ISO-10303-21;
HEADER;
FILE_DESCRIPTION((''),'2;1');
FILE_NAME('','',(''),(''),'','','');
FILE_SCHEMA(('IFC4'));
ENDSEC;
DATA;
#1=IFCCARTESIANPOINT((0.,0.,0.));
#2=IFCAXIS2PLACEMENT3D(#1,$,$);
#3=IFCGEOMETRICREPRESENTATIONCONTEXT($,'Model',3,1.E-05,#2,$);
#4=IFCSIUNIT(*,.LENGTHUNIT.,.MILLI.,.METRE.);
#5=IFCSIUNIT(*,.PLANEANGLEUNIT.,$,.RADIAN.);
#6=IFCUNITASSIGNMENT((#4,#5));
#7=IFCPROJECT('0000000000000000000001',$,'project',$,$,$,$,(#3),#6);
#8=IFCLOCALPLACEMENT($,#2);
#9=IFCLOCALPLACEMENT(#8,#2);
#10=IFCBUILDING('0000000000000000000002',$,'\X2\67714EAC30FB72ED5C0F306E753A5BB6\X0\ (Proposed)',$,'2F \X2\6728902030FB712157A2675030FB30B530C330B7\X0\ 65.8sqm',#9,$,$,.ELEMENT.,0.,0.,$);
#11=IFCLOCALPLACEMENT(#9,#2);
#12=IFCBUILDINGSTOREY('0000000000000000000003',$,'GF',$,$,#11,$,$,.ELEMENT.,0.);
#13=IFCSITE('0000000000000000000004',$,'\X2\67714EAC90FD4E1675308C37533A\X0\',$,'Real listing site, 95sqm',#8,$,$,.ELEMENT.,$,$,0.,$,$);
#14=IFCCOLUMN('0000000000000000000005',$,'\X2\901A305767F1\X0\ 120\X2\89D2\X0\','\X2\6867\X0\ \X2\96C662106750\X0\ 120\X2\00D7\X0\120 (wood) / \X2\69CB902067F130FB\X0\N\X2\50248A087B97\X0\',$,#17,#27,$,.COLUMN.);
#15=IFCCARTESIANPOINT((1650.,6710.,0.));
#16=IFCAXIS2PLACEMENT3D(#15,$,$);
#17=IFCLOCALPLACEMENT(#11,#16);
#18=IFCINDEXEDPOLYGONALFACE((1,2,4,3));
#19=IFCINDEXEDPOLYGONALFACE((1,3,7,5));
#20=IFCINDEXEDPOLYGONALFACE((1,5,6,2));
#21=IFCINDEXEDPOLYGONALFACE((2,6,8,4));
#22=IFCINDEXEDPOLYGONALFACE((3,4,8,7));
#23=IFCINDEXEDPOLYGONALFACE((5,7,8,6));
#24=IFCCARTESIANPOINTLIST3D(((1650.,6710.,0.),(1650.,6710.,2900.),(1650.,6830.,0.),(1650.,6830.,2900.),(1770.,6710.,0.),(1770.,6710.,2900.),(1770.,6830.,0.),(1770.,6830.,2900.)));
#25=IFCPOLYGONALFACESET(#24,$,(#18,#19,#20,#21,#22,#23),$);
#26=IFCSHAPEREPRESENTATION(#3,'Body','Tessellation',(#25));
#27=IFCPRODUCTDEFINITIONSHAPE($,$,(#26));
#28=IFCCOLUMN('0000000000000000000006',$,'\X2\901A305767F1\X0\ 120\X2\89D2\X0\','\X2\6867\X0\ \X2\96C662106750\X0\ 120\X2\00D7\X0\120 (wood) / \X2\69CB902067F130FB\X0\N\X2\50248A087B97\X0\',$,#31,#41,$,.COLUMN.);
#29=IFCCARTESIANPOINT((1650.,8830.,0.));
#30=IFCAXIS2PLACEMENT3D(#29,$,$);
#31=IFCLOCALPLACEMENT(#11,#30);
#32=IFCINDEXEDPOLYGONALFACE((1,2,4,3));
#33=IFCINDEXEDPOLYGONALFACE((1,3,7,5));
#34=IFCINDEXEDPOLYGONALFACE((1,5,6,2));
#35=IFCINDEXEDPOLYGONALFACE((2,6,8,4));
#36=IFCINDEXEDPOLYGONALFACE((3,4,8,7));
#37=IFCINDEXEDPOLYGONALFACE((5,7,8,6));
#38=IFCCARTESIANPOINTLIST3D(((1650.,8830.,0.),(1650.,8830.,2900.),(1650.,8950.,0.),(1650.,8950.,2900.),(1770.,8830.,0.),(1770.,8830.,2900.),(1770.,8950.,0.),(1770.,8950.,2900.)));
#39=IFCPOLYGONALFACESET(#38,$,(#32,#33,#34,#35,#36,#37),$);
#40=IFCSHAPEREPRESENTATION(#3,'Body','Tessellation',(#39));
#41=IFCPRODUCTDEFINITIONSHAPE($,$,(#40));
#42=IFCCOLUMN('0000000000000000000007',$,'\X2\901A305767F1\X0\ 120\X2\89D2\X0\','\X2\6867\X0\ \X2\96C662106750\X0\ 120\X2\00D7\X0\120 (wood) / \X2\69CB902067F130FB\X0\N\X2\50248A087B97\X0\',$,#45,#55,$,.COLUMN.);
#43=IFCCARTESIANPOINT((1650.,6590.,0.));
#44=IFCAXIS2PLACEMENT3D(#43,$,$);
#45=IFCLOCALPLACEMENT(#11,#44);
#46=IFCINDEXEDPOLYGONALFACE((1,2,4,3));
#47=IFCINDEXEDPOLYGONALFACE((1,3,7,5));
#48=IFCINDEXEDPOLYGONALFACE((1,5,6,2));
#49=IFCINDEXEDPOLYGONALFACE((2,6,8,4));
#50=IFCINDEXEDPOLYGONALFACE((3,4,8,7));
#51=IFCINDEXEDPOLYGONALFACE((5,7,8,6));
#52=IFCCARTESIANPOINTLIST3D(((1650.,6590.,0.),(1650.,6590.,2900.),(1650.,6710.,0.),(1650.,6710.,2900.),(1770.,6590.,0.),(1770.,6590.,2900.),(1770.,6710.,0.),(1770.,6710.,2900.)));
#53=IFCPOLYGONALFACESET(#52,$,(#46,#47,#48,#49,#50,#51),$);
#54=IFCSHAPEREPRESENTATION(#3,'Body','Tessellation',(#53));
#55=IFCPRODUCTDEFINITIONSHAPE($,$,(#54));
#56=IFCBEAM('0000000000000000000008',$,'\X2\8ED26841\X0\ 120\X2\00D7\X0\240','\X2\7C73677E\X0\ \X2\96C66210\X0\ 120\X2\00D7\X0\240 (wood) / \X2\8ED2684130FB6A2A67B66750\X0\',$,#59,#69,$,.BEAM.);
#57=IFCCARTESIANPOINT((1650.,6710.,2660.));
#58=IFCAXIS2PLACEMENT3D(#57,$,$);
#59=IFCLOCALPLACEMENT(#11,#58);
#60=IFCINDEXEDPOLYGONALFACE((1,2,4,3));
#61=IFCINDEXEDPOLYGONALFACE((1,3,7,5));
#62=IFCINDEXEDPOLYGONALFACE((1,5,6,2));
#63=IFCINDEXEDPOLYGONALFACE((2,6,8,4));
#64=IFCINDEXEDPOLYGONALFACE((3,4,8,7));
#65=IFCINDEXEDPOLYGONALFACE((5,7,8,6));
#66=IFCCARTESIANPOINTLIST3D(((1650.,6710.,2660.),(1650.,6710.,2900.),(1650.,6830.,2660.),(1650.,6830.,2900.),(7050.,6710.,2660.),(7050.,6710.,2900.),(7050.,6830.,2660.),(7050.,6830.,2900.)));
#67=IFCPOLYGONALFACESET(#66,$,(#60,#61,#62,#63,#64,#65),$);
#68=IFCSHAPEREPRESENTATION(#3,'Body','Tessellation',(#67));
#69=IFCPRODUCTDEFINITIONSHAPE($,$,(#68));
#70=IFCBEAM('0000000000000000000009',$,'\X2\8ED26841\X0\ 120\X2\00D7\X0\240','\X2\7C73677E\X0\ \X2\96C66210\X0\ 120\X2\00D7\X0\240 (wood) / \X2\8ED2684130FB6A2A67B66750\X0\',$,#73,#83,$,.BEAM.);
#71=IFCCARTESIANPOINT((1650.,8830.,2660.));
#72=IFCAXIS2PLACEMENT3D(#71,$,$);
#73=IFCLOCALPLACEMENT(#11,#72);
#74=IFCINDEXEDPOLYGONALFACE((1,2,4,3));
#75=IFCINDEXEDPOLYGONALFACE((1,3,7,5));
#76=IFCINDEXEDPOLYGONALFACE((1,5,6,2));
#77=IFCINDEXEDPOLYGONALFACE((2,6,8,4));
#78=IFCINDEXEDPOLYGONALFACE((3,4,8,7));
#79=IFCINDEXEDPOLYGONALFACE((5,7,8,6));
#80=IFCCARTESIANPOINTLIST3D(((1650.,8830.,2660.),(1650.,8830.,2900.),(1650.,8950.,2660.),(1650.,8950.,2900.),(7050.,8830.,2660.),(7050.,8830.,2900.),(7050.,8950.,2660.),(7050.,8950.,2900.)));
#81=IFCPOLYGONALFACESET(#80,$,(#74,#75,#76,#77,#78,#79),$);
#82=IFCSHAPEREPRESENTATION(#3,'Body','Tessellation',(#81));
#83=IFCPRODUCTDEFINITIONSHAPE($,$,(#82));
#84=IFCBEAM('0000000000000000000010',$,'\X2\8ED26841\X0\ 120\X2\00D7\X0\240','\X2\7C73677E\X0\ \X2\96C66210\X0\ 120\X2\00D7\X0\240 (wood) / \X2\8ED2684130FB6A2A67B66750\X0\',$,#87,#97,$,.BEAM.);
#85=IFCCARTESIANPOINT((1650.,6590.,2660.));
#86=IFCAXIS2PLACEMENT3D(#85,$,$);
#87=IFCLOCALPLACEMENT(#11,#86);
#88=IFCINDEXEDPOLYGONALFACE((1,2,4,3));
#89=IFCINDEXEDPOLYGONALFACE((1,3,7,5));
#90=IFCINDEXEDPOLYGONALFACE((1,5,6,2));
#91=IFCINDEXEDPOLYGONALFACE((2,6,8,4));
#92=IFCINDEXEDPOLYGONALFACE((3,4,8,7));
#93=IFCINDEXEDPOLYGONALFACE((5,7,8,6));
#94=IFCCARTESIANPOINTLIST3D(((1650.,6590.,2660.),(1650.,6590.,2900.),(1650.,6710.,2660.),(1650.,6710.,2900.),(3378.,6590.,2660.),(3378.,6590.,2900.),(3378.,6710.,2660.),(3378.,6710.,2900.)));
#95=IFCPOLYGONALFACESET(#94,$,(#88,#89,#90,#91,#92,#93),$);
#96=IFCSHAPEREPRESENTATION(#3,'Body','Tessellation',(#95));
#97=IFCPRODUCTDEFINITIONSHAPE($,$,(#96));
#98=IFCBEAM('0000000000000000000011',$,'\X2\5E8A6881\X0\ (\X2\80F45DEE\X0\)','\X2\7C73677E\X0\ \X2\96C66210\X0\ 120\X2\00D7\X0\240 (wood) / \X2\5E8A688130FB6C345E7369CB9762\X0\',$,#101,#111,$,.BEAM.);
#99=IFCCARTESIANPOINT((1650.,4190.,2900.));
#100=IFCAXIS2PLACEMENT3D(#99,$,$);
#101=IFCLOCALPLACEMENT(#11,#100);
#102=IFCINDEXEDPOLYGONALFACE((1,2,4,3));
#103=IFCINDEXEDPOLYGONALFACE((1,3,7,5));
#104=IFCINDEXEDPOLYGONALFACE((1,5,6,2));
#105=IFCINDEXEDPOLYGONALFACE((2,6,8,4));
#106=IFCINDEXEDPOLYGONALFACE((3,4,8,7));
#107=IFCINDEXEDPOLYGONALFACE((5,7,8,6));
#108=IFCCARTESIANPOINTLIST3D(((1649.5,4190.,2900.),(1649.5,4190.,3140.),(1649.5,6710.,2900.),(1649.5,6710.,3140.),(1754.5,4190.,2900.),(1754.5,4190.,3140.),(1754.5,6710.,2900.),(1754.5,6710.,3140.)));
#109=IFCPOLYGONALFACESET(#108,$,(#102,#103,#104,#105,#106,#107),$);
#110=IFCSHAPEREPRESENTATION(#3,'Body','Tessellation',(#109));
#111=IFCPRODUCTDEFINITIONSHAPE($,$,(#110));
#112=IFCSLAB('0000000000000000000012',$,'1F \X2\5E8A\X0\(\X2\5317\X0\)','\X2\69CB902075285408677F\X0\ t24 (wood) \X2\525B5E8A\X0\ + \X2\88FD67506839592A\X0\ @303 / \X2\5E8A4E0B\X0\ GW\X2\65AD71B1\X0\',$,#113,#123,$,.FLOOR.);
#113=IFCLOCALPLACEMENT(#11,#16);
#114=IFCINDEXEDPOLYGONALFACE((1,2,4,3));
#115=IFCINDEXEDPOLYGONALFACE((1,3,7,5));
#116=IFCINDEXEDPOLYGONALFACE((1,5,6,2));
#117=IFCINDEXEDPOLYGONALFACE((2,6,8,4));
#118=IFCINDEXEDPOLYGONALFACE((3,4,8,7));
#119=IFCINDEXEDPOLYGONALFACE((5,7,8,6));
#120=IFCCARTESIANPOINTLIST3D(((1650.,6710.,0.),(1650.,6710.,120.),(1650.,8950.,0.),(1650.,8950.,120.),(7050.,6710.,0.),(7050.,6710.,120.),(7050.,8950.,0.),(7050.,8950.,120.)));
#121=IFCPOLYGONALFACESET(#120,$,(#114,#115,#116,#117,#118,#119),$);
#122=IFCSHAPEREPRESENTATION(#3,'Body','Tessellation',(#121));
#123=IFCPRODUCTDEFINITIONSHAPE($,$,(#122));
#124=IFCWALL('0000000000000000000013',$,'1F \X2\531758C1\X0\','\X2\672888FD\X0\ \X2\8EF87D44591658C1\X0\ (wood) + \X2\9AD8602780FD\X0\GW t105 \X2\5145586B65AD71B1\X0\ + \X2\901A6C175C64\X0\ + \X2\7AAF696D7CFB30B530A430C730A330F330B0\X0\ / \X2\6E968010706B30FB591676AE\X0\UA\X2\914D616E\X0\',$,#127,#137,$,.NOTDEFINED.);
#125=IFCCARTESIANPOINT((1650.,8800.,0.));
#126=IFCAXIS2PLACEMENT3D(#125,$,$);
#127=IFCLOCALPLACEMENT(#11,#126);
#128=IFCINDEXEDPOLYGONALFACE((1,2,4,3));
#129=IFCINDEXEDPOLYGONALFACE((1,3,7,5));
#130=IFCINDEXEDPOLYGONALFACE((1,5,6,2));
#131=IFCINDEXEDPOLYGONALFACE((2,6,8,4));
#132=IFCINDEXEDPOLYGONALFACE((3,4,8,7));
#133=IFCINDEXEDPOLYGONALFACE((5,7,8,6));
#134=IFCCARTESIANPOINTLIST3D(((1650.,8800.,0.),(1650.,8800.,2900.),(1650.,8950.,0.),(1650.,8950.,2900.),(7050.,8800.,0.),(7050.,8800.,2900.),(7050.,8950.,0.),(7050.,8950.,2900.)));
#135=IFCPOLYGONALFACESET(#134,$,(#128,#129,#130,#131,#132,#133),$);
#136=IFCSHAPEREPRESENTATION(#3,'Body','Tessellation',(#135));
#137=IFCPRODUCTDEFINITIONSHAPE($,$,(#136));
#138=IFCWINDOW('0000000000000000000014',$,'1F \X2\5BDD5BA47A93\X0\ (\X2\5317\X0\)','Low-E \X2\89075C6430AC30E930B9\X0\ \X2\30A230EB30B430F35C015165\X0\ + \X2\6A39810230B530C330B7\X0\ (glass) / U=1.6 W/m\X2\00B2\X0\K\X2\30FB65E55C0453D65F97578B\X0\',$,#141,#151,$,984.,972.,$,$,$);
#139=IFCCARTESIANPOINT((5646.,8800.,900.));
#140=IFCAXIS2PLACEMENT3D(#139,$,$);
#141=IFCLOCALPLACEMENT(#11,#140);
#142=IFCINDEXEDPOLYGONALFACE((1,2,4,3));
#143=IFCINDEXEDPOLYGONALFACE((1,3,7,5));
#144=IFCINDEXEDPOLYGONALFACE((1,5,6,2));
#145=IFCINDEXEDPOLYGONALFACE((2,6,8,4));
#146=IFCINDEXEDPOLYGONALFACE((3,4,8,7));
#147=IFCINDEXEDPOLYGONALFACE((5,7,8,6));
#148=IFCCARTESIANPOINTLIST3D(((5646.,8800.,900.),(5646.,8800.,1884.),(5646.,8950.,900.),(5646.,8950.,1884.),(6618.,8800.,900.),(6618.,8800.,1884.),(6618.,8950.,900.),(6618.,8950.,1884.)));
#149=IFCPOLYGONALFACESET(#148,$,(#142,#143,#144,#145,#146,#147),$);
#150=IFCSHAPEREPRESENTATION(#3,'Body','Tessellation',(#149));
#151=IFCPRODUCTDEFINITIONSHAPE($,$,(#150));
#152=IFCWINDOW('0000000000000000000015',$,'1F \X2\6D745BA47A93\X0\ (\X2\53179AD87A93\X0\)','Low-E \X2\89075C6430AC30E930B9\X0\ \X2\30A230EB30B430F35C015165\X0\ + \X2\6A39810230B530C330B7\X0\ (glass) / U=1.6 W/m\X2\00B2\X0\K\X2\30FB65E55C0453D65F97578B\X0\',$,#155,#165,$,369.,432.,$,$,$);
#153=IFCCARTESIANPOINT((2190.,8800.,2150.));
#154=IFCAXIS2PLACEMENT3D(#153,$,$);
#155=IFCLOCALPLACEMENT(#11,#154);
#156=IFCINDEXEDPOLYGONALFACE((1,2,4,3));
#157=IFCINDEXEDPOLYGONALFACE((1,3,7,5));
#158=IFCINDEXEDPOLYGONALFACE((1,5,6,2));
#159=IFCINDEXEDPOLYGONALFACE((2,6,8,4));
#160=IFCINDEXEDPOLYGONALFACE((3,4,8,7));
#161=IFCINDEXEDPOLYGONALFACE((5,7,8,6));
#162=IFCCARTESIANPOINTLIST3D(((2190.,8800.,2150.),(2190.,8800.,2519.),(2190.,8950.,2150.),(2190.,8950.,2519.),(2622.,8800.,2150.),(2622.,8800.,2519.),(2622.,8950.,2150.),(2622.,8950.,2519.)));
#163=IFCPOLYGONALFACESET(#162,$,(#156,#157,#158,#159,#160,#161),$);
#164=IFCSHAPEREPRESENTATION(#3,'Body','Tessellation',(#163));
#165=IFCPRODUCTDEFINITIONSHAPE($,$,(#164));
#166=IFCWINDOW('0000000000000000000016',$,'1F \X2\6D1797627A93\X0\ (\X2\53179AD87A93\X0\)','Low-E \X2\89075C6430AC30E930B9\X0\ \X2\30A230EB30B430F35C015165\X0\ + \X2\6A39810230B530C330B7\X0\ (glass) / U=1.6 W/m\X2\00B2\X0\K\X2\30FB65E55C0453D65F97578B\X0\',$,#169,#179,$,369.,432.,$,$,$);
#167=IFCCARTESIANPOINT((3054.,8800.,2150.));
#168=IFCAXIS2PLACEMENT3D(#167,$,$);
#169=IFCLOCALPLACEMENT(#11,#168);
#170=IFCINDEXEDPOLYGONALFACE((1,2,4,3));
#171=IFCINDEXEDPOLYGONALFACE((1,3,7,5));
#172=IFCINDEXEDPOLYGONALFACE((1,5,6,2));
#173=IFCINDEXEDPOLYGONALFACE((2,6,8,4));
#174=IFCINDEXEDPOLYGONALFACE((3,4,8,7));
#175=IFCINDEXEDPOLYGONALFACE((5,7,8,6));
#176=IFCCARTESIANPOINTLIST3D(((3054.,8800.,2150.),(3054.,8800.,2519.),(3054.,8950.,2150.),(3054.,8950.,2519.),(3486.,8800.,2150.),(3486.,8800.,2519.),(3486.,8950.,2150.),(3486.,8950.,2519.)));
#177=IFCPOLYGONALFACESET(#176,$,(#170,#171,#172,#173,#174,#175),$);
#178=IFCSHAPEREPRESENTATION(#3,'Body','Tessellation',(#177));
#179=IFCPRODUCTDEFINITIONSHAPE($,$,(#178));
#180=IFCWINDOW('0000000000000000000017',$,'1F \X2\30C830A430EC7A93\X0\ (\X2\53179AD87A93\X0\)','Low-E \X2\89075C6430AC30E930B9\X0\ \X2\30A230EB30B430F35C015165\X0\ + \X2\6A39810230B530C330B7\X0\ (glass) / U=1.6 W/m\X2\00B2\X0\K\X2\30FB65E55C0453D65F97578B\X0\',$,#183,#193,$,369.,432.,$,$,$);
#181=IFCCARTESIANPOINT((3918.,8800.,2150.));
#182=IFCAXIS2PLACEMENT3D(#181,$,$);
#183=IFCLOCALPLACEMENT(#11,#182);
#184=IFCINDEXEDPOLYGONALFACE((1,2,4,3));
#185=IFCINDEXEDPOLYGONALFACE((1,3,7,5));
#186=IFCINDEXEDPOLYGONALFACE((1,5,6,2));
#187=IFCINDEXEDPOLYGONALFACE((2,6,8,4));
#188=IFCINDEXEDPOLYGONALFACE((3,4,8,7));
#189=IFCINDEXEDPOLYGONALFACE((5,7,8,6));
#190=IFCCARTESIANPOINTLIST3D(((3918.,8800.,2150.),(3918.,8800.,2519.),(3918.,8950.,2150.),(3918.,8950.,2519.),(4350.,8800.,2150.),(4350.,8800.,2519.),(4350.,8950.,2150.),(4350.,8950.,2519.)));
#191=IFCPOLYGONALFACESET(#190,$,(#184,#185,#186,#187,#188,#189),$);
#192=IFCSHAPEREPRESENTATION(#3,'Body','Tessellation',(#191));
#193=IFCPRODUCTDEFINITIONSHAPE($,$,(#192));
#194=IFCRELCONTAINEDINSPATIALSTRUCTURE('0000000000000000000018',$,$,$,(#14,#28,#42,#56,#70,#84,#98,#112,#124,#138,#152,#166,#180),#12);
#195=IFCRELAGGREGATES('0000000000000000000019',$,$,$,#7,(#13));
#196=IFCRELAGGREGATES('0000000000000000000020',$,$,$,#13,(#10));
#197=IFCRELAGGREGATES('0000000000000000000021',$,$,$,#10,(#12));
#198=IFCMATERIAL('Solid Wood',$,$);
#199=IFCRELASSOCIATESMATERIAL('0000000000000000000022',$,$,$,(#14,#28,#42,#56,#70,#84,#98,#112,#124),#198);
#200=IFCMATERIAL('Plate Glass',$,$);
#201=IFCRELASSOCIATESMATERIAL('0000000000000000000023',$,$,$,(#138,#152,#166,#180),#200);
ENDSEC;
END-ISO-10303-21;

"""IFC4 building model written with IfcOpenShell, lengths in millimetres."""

from ifc_helpers import new_model, si_unit, frame, frame_2d, origin, place, context, project, spatial, rectangle, extrude, material, element, fill, save


model = new_model("IFC4")

# Units and contexts
model_context = context("Model", 3, precision=1e-05, world=origin())
ifc_project = project(units=[si_unit("LENGTHUNIT", "METRE", prefix="MILLI"), si_unit("PLANEANGLEUNIT", "RADIAN")], contexts=[model_context])

# Site, building, storey
site_placement = place(None, origin())
site = spatial("IfcSite", under=ifc_project, at=site_placement, Name="東京都世田谷区", ObjectType="Real listing site, 95sqm", CompositionType="ELEMENT", RefElevation=0.0)
building_placement = place(site_placement, origin())
building = spatial("IfcBuilding", under=site, at=building_placement, Name="東京・狭小の町家 (Proposed)", ObjectType="2F 木造・無垢材・サッシ 65.8sqm", CompositionType="ELEMENT", ElevationOfRefHeight=0.0, ElevationOfTerrain=0.0)
storey_placement = place(building_placement, origin())
storey = spatial("IfcBuildingStorey", under=building, at=storey_placement, Name="GF", CompositionType="ELEMENT", Elevation=0.0)

# Columns
ifc_material_1 = material(Name="Solid Wood")
column_1_placement = place(storey_placement, frame((1650.0, 6710.0, 0.0)))
element("IfcColumn", 1, at=column_1_placement, inside=storey, material=ifc_material_1, Name="通し柱 120角", Description="桧 集成材 120×120 (wood) / 構造柱・N値計算", PredefinedType="COLUMN", context=model_context, shape_type="SweptSolid", body=[
    extrude(rectangle(XDim=120.0, YDim=120.0, at=frame_2d((60.0, 60.0))), frame((1650.0, 6710.0, 0.0)), (0.0, 0.0, 1.0), 2900.0),
])
column_2_placement = place(storey_placement, frame((1650.0, 8830.0, 0.0)))
element("IfcColumn", 2, at=column_2_placement, inside=storey, material=ifc_material_1, Name="通し柱 120角", Description="桧 集成材 120×120 (wood) / 構造柱・N値計算", PredefinedType="COLUMN", context=model_context, shape_type="SweptSolid", body=[
    extrude(rectangle(XDim=120.0, YDim=120.0, at=frame_2d((60.0, 60.0))), frame((1650.0, 8830.0, 0.0)), (0.0, 0.0, 1.0), 2900.0),
])
column_3_placement = place(storey_placement, frame((1650.0, 6590.0, 0.0)))
element("IfcColumn", 3, at=column_3_placement, inside=storey, material=ifc_material_1, Name="通し柱 120角", Description="桧 集成材 120×120 (wood) / 構造柱・N値計算", PredefinedType="COLUMN", context=model_context, shape_type="SweptSolid", body=[
    extrude(rectangle(XDim=120.0, YDim=120.0, at=frame_2d((60.0, 60.0))), frame((1650.0, 6590.0, 0.0)), (0.0, 0.0, 1.0), 2900.0),
])

# Beams
beam_1_placement = place(storey_placement, frame((1650.0, 6710.0, 2660.0)))
element("IfcBeam", 4, at=beam_1_placement, inside=storey, material=ifc_material_1, Name="軒桁 120×240", Description="米松 集成 120×240 (wood) / 軒桁・横架材", PredefinedType="BEAM", context=model_context, shape_type="SweptSolid", body=[
    extrude(rectangle(XDim=5400.0, YDim=120.0, at=frame_2d((2700.0, 60.0))), frame((1650.0, 6710.0, 2660.0)), (0.0, 0.0, 1.0), 240.0),
])
beam_2_placement = place(storey_placement, frame((1650.0, 8830.0, 2660.0)))
element("IfcBeam", 5, at=beam_2_placement, inside=storey, material=ifc_material_1, Name="軒桁 120×240", Description="米松 集成 120×240 (wood) / 軒桁・横架材", PredefinedType="BEAM", context=model_context, shape_type="SweptSolid", body=[
    extrude(rectangle(XDim=5400.0, YDim=120.0, at=frame_2d((2700.0, 60.0))), frame((1650.0, 8830.0, 2660.0)), (0.0, 0.0, 1.0), 240.0),
])
beam_3_placement = place(storey_placement, frame((1650.0, 6590.0, 2660.0)))
element("IfcBeam", 6, at=beam_3_placement, inside=storey, material=ifc_material_1, Name="軒桁 120×240", Description="米松 集成 120×240 (wood) / 軒桁・横架材", PredefinedType="BEAM", context=model_context, shape_type="SweptSolid", body=[
    extrude(rectangle(XDim=1728.0, YDim=120.0, at=frame_2d((864.0, 60.0))), frame((1650.0, 6590.0, 2660.0)), (0.0, 0.0, 1.0), 240.0),
])
beam_4_placement = place(storey_placement, frame((1650.0, 4190.0, 2900.0)))
element("IfcBeam", 7, at=beam_4_placement, inside=storey, material=ifc_material_1, Name="床梁 (胴差)", Description="米松 集成 120×240 (wood) / 床梁・水平構面", PredefinedType="BEAM", context=model_context, shape_type="SweptSolid", body=[
    extrude(rectangle(XDim=105.0, YDim=2520.0, at=frame_2d((52.0, 1260.0))), frame((1650.0, 4190.0, 2900.0)), (0.0, 0.0, 1.0), 240.0),
])

# Slab
slab_placement = place(storey_placement, frame((1650.0, 6710.0, 0.0)))
element("IfcSlab", 8, at=slab_placement, inside=storey, material=ifc_material_1, Name="1F 床(北)", Description="構造用合板 t24 (wood) 剛床 + 製材根太 @303 / 床下 GW断熱", PredefinedType="FLOOR", context=model_context, shape_type="SweptSolid", body=[
    extrude(rectangle(XDim=5400.0, YDim=2240.0, at=frame_2d((2700.0, 1120.0))), frame((1650.0, 6710.0, 0.0)), (0.0, 0.0, 1.0), 120.0),
])

# Wall, openings, windows
wall_1_placement = place(storey_placement, frame((1650.0, 8800.0, 0.0)))
wall_1 = element("IfcWall", 9, at=wall_1_placement, inside=storey, material=ifc_material_1, Name="1F 北壁", Description="木製 軸組外壁 (wood) + 高性能GW t105 充填断熱 + 通気層 + 窯業系サイディング / 準耐火・外皮UA配慮", PredefinedType="NOTDEFINED", context=model_context, shape_type="SweptSolid", body=[
    extrude(rectangle(XDim=5400.0, YDim=150.0, at=frame_2d((2700.0, 75.0))), frame((1650.0, 8800.0, 0.0)), (0.0, 0.0, 1.0), 2900.0),
])
opening_1_placement = place(storey_placement, frame((5646.0, 8800.0, 900.0)))
opening_1 = element("IfcOpeningElement", 10, at=opening_1_placement, cuts=wall_1, PredefinedType="NOTDEFINED", context=model_context, shape_type="SweptSolid", body=[
    extrude(rectangle(XDim=972.0, YDim=150.0, at=frame_2d((486.0, 75.0))), frame((5646.0, 8800.0, 900.0)), (0.0, 0.0, 1.0), 984.0),
])
opening_2_placement = place(storey_placement, frame((2190.0, 8800.0, 2150.0)))
opening_2 = element("IfcOpeningElement", 11, at=opening_2_placement, cuts=wall_1, PredefinedType="NOTDEFINED", context=model_context, shape_type="SweptSolid", body=[
    extrude(rectangle(XDim=432.0, YDim=150.0, at=frame_2d((216.0, 75.0))), frame((2190.0, 8800.0, 2150.0)), (0.0, 0.0, 1.0), 369.0),
])
opening_3_placement = place(storey_placement, frame((3054.0, 8800.0, 2150.0)))
opening_3 = element("IfcOpeningElement", 12, at=opening_3_placement, cuts=wall_1, PredefinedType="NOTDEFINED", context=model_context, shape_type="SweptSolid", body=[
    extrude(rectangle(XDim=432.0, YDim=150.0, at=frame_2d((216.0, 75.0))), frame((3054.0, 8800.0, 2150.0)), (0.0, 0.0, 1.0), 369.0),
])
opening_4_placement = place(storey_placement, frame((3918.0, 8800.0, 2150.0)))
opening_4 = element("IfcOpeningElement", 13, at=opening_4_placement, cuts=wall_1, PredefinedType="NOTDEFINED", context=model_context, shape_type="SweptSolid", body=[
    extrude(rectangle(XDim=432.0, YDim=150.0, at=frame_2d((216.0, 75.0))), frame((3918.0, 8800.0, 2150.0)), (0.0, 0.0, 1.0), 369.0),
])
ifc_material_2 = material(Name="Plate Glass")
window_1_placement = place(storey_placement, frame((5646.0, 8800.0, 900.0)))
window_1 = element("IfcWindow", 14, at=window_1_placement, inside=storey, material=ifc_material_2, Name="1F 寝室窓 (北)", Description="Low-E 複層ガラス アルゴン封入 + 樹脂サッシ (glass) / U=1.6 W/m²K・日射取得型", OverallHeight=984.0, OverallWidth=972.0, context=model_context, shape_type="SweptSolid", body=[
    extrude(rectangle(XDim=972.0, YDim=150.0, at=frame_2d((486.0, 75.0))), frame((5646.0, 8800.0, 900.0)), (0.0, 0.0, 1.0), 984.0),
])
fill(opening_1, window_1)
window_2_placement = place(storey_placement, frame((2190.0, 8800.0, 2150.0)))
window_2 = element("IfcWindow", 15, at=window_2_placement, inside=storey, material=ifc_material_2, Name="1F 浴室窓 (北高窓)", Description="Low-E 複層ガラス アルゴン封入 + 樹脂サッシ (glass) / U=1.6 W/m²K・日射取得型", OverallHeight=369.0, OverallWidth=432.0, context=model_context, shape_type="SweptSolid", body=[
    extrude(rectangle(XDim=432.0, YDim=150.0, at=frame_2d((216.0, 75.0))), frame((2190.0, 8800.0, 2150.0)), (0.0, 0.0, 1.0), 369.0),
])
fill(opening_2, window_2)
window_3_placement = place(storey_placement, frame((3054.0, 8800.0, 2150.0)))
window_3 = element("IfcWindow", 16, at=window_3_placement, inside=storey, material=ifc_material_2, Name="1F 洗面窓 (北高窓)", Description="Low-E 複層ガラス アルゴン封入 + 樹脂サッシ (glass) / U=1.6 W/m²K・日射取得型", OverallHeight=369.0, OverallWidth=432.0, context=model_context, shape_type="SweptSolid", body=[
    extrude(rectangle(XDim=432.0, YDim=150.0, at=frame_2d((216.0, 75.0))), frame((3054.0, 8800.0, 2150.0)), (0.0, 0.0, 1.0), 369.0),
])
fill(opening_3, window_3)
window_4_placement = place(storey_placement, frame((3918.0, 8800.0, 2150.0)))
window_4 = element("IfcWindow", 17, at=window_4_placement, inside=storey, material=ifc_material_2, Name="1F トイレ窓 (北高窓)", Description="Low-E 複層ガラス アルゴン封入 + 樹脂サッシ (glass) / U=1.6 W/m²K・日射取得型", OverallHeight=369.0, OverallWidth=432.0, context=model_context, shape_type="SweptSolid", body=[
    extrude(rectangle(XDim=432.0, YDim=150.0, at=frame_2d((216.0, 75.0))), frame((3918.0, 8800.0, 2150.0)), (0.0, 0.0, 1.0), 369.0),
])
fill(opening_4, window_4)

save(model, "model.ifc")
